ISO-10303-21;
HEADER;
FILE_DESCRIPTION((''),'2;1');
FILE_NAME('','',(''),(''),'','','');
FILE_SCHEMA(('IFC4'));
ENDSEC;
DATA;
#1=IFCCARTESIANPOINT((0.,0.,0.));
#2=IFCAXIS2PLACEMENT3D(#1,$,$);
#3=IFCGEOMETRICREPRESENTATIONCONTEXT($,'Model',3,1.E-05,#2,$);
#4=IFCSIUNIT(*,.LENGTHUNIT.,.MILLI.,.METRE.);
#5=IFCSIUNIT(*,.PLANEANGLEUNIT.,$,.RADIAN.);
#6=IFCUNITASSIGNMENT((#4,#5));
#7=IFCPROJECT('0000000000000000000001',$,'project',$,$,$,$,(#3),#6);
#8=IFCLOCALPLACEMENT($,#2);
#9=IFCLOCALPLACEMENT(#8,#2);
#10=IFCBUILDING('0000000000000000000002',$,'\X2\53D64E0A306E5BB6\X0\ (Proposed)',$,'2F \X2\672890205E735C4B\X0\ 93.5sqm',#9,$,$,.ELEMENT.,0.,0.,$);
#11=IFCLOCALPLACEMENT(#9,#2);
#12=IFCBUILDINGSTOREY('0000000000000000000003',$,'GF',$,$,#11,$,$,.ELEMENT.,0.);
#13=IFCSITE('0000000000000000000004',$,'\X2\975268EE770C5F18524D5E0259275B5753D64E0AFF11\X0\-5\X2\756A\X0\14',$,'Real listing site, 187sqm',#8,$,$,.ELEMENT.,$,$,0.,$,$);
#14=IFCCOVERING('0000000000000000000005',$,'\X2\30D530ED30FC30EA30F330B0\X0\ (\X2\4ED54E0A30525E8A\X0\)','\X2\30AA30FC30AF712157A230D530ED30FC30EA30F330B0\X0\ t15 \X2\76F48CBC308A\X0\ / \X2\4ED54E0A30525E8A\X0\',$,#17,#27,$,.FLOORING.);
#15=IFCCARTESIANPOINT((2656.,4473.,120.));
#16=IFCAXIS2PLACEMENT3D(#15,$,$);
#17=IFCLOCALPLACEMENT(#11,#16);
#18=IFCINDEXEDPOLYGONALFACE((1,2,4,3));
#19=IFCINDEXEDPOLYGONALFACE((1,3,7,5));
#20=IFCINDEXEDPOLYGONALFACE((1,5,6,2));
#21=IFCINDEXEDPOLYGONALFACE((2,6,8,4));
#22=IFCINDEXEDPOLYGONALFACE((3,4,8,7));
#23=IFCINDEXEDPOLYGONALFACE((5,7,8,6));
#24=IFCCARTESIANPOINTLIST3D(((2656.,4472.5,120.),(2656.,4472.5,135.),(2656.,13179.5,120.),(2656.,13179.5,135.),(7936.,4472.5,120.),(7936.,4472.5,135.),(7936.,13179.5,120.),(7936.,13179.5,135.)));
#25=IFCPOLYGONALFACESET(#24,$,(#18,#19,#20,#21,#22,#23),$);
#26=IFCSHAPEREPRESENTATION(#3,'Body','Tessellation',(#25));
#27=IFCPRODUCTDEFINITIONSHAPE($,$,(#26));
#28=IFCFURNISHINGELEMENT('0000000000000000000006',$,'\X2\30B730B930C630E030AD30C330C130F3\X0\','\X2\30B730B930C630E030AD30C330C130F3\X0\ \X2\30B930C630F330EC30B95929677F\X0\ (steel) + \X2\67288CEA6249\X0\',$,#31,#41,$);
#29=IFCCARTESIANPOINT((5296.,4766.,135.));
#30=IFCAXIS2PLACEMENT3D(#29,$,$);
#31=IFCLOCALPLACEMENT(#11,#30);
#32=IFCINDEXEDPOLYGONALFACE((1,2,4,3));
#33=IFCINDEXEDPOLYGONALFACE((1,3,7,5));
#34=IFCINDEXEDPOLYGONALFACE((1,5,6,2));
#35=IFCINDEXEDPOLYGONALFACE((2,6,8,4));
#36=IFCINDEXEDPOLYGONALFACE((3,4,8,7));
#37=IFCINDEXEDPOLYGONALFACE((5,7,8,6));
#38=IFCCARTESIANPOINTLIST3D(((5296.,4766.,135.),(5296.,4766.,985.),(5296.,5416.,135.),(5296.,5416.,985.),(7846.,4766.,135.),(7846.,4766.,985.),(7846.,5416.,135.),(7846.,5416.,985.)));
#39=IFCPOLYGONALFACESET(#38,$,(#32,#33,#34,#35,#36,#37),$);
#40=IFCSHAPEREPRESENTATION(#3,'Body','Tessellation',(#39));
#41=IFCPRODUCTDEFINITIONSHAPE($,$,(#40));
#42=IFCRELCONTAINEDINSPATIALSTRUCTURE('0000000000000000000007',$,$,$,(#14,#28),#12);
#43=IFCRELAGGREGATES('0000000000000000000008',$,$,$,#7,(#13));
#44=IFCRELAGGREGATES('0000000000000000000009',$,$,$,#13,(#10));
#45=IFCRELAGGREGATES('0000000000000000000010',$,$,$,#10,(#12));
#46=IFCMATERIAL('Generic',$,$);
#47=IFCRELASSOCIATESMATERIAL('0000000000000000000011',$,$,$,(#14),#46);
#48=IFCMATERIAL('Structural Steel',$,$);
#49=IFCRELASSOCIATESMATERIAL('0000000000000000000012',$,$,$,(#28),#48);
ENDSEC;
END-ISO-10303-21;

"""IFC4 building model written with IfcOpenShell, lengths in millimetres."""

from ifc_helpers import new_model, si_unit, frame, frame_2d, origin, place, context, project, spatial, rectangle, extrude, material, element, save


model = new_model("IFC4")

# Units and contexts
model_context = context("Model", 3, precision=1e-05, world=origin())
ifc_project = project(units=[si_unit("LENGTHUNIT", "METRE", prefix="MILLI"), si_unit("PLANEANGLEUNIT", "RADIAN")], contexts=[model_context])

# Site, building, storey
site_placement = place(None, origin())
site = spatial("IfcSite", under=ifc_project, at=site_placement, Name="青森県弘前市大字取上１-5番14", ObjectType="Real listing site, 187sqm", CompositionType="ELEMENT", RefElevation=0.0)
building_placement = place(site_placement, origin())
building = spatial("IfcBuilding", under=site, at=building_placement, Name="取上の家 (Proposed)", ObjectType="2F 木造平屋 93.5sqm", CompositionType="ELEMENT", ElevationOfRefHeight=0.0, ElevationOfTerrain=0.0)
storey_placement = place(building_placement, origin())
storey = spatial("IfcBuildingStorey", under=building, at=storey_placement, Name="GF", CompositionType="ELEMENT", Elevation=0.0)

# Covering
ifc_material_1 = material(Name="Generic")
covering_placement = place(storey_placement, frame((2656.0, 4473.0, 120.0)))
element("IfcCovering", 1, at=covering_placement, inside=storey, material=ifc_material_1, Name="フローリング (仕上げ床)", Description="オーク無垢フローリング t15 直貼り / 仕上げ床", PredefinedType="FLOORING", context=model_context, shape_type="SweptSolid", body=[
    extrude(rectangle(XDim=5280.0, YDim=8707.0, at=frame_2d((2640.0, 4353.0))), frame((2656.0, 4473.0, 120.0)), (0.0, 0.0, 1.0), 15.0),
])

# Furnishing element
ifc_material_2 = material(Name="Structural Steel")
furnishing_placement = place(storey_placement, frame((5296.0, 4766.0, 135.0)))
element("IfcFurnishingElement", 2, at=furnishing_placement, inside=storey, material=ifc_material_2, Name="システムキッチン", Description="システムキッチン ステンレス天板 (steel) + 木質扉", context=model_context, shape_type="SweptSolid", body=[
    extrude(rectangle(XDim=2550.0, YDim=650.0, at=frame_2d((1275.0, 325.0))), frame((5296.0, 4766.0, 135.0)), (0.0, 0.0, 1.0), 850.0),
])

save(model, "model.ifc")
